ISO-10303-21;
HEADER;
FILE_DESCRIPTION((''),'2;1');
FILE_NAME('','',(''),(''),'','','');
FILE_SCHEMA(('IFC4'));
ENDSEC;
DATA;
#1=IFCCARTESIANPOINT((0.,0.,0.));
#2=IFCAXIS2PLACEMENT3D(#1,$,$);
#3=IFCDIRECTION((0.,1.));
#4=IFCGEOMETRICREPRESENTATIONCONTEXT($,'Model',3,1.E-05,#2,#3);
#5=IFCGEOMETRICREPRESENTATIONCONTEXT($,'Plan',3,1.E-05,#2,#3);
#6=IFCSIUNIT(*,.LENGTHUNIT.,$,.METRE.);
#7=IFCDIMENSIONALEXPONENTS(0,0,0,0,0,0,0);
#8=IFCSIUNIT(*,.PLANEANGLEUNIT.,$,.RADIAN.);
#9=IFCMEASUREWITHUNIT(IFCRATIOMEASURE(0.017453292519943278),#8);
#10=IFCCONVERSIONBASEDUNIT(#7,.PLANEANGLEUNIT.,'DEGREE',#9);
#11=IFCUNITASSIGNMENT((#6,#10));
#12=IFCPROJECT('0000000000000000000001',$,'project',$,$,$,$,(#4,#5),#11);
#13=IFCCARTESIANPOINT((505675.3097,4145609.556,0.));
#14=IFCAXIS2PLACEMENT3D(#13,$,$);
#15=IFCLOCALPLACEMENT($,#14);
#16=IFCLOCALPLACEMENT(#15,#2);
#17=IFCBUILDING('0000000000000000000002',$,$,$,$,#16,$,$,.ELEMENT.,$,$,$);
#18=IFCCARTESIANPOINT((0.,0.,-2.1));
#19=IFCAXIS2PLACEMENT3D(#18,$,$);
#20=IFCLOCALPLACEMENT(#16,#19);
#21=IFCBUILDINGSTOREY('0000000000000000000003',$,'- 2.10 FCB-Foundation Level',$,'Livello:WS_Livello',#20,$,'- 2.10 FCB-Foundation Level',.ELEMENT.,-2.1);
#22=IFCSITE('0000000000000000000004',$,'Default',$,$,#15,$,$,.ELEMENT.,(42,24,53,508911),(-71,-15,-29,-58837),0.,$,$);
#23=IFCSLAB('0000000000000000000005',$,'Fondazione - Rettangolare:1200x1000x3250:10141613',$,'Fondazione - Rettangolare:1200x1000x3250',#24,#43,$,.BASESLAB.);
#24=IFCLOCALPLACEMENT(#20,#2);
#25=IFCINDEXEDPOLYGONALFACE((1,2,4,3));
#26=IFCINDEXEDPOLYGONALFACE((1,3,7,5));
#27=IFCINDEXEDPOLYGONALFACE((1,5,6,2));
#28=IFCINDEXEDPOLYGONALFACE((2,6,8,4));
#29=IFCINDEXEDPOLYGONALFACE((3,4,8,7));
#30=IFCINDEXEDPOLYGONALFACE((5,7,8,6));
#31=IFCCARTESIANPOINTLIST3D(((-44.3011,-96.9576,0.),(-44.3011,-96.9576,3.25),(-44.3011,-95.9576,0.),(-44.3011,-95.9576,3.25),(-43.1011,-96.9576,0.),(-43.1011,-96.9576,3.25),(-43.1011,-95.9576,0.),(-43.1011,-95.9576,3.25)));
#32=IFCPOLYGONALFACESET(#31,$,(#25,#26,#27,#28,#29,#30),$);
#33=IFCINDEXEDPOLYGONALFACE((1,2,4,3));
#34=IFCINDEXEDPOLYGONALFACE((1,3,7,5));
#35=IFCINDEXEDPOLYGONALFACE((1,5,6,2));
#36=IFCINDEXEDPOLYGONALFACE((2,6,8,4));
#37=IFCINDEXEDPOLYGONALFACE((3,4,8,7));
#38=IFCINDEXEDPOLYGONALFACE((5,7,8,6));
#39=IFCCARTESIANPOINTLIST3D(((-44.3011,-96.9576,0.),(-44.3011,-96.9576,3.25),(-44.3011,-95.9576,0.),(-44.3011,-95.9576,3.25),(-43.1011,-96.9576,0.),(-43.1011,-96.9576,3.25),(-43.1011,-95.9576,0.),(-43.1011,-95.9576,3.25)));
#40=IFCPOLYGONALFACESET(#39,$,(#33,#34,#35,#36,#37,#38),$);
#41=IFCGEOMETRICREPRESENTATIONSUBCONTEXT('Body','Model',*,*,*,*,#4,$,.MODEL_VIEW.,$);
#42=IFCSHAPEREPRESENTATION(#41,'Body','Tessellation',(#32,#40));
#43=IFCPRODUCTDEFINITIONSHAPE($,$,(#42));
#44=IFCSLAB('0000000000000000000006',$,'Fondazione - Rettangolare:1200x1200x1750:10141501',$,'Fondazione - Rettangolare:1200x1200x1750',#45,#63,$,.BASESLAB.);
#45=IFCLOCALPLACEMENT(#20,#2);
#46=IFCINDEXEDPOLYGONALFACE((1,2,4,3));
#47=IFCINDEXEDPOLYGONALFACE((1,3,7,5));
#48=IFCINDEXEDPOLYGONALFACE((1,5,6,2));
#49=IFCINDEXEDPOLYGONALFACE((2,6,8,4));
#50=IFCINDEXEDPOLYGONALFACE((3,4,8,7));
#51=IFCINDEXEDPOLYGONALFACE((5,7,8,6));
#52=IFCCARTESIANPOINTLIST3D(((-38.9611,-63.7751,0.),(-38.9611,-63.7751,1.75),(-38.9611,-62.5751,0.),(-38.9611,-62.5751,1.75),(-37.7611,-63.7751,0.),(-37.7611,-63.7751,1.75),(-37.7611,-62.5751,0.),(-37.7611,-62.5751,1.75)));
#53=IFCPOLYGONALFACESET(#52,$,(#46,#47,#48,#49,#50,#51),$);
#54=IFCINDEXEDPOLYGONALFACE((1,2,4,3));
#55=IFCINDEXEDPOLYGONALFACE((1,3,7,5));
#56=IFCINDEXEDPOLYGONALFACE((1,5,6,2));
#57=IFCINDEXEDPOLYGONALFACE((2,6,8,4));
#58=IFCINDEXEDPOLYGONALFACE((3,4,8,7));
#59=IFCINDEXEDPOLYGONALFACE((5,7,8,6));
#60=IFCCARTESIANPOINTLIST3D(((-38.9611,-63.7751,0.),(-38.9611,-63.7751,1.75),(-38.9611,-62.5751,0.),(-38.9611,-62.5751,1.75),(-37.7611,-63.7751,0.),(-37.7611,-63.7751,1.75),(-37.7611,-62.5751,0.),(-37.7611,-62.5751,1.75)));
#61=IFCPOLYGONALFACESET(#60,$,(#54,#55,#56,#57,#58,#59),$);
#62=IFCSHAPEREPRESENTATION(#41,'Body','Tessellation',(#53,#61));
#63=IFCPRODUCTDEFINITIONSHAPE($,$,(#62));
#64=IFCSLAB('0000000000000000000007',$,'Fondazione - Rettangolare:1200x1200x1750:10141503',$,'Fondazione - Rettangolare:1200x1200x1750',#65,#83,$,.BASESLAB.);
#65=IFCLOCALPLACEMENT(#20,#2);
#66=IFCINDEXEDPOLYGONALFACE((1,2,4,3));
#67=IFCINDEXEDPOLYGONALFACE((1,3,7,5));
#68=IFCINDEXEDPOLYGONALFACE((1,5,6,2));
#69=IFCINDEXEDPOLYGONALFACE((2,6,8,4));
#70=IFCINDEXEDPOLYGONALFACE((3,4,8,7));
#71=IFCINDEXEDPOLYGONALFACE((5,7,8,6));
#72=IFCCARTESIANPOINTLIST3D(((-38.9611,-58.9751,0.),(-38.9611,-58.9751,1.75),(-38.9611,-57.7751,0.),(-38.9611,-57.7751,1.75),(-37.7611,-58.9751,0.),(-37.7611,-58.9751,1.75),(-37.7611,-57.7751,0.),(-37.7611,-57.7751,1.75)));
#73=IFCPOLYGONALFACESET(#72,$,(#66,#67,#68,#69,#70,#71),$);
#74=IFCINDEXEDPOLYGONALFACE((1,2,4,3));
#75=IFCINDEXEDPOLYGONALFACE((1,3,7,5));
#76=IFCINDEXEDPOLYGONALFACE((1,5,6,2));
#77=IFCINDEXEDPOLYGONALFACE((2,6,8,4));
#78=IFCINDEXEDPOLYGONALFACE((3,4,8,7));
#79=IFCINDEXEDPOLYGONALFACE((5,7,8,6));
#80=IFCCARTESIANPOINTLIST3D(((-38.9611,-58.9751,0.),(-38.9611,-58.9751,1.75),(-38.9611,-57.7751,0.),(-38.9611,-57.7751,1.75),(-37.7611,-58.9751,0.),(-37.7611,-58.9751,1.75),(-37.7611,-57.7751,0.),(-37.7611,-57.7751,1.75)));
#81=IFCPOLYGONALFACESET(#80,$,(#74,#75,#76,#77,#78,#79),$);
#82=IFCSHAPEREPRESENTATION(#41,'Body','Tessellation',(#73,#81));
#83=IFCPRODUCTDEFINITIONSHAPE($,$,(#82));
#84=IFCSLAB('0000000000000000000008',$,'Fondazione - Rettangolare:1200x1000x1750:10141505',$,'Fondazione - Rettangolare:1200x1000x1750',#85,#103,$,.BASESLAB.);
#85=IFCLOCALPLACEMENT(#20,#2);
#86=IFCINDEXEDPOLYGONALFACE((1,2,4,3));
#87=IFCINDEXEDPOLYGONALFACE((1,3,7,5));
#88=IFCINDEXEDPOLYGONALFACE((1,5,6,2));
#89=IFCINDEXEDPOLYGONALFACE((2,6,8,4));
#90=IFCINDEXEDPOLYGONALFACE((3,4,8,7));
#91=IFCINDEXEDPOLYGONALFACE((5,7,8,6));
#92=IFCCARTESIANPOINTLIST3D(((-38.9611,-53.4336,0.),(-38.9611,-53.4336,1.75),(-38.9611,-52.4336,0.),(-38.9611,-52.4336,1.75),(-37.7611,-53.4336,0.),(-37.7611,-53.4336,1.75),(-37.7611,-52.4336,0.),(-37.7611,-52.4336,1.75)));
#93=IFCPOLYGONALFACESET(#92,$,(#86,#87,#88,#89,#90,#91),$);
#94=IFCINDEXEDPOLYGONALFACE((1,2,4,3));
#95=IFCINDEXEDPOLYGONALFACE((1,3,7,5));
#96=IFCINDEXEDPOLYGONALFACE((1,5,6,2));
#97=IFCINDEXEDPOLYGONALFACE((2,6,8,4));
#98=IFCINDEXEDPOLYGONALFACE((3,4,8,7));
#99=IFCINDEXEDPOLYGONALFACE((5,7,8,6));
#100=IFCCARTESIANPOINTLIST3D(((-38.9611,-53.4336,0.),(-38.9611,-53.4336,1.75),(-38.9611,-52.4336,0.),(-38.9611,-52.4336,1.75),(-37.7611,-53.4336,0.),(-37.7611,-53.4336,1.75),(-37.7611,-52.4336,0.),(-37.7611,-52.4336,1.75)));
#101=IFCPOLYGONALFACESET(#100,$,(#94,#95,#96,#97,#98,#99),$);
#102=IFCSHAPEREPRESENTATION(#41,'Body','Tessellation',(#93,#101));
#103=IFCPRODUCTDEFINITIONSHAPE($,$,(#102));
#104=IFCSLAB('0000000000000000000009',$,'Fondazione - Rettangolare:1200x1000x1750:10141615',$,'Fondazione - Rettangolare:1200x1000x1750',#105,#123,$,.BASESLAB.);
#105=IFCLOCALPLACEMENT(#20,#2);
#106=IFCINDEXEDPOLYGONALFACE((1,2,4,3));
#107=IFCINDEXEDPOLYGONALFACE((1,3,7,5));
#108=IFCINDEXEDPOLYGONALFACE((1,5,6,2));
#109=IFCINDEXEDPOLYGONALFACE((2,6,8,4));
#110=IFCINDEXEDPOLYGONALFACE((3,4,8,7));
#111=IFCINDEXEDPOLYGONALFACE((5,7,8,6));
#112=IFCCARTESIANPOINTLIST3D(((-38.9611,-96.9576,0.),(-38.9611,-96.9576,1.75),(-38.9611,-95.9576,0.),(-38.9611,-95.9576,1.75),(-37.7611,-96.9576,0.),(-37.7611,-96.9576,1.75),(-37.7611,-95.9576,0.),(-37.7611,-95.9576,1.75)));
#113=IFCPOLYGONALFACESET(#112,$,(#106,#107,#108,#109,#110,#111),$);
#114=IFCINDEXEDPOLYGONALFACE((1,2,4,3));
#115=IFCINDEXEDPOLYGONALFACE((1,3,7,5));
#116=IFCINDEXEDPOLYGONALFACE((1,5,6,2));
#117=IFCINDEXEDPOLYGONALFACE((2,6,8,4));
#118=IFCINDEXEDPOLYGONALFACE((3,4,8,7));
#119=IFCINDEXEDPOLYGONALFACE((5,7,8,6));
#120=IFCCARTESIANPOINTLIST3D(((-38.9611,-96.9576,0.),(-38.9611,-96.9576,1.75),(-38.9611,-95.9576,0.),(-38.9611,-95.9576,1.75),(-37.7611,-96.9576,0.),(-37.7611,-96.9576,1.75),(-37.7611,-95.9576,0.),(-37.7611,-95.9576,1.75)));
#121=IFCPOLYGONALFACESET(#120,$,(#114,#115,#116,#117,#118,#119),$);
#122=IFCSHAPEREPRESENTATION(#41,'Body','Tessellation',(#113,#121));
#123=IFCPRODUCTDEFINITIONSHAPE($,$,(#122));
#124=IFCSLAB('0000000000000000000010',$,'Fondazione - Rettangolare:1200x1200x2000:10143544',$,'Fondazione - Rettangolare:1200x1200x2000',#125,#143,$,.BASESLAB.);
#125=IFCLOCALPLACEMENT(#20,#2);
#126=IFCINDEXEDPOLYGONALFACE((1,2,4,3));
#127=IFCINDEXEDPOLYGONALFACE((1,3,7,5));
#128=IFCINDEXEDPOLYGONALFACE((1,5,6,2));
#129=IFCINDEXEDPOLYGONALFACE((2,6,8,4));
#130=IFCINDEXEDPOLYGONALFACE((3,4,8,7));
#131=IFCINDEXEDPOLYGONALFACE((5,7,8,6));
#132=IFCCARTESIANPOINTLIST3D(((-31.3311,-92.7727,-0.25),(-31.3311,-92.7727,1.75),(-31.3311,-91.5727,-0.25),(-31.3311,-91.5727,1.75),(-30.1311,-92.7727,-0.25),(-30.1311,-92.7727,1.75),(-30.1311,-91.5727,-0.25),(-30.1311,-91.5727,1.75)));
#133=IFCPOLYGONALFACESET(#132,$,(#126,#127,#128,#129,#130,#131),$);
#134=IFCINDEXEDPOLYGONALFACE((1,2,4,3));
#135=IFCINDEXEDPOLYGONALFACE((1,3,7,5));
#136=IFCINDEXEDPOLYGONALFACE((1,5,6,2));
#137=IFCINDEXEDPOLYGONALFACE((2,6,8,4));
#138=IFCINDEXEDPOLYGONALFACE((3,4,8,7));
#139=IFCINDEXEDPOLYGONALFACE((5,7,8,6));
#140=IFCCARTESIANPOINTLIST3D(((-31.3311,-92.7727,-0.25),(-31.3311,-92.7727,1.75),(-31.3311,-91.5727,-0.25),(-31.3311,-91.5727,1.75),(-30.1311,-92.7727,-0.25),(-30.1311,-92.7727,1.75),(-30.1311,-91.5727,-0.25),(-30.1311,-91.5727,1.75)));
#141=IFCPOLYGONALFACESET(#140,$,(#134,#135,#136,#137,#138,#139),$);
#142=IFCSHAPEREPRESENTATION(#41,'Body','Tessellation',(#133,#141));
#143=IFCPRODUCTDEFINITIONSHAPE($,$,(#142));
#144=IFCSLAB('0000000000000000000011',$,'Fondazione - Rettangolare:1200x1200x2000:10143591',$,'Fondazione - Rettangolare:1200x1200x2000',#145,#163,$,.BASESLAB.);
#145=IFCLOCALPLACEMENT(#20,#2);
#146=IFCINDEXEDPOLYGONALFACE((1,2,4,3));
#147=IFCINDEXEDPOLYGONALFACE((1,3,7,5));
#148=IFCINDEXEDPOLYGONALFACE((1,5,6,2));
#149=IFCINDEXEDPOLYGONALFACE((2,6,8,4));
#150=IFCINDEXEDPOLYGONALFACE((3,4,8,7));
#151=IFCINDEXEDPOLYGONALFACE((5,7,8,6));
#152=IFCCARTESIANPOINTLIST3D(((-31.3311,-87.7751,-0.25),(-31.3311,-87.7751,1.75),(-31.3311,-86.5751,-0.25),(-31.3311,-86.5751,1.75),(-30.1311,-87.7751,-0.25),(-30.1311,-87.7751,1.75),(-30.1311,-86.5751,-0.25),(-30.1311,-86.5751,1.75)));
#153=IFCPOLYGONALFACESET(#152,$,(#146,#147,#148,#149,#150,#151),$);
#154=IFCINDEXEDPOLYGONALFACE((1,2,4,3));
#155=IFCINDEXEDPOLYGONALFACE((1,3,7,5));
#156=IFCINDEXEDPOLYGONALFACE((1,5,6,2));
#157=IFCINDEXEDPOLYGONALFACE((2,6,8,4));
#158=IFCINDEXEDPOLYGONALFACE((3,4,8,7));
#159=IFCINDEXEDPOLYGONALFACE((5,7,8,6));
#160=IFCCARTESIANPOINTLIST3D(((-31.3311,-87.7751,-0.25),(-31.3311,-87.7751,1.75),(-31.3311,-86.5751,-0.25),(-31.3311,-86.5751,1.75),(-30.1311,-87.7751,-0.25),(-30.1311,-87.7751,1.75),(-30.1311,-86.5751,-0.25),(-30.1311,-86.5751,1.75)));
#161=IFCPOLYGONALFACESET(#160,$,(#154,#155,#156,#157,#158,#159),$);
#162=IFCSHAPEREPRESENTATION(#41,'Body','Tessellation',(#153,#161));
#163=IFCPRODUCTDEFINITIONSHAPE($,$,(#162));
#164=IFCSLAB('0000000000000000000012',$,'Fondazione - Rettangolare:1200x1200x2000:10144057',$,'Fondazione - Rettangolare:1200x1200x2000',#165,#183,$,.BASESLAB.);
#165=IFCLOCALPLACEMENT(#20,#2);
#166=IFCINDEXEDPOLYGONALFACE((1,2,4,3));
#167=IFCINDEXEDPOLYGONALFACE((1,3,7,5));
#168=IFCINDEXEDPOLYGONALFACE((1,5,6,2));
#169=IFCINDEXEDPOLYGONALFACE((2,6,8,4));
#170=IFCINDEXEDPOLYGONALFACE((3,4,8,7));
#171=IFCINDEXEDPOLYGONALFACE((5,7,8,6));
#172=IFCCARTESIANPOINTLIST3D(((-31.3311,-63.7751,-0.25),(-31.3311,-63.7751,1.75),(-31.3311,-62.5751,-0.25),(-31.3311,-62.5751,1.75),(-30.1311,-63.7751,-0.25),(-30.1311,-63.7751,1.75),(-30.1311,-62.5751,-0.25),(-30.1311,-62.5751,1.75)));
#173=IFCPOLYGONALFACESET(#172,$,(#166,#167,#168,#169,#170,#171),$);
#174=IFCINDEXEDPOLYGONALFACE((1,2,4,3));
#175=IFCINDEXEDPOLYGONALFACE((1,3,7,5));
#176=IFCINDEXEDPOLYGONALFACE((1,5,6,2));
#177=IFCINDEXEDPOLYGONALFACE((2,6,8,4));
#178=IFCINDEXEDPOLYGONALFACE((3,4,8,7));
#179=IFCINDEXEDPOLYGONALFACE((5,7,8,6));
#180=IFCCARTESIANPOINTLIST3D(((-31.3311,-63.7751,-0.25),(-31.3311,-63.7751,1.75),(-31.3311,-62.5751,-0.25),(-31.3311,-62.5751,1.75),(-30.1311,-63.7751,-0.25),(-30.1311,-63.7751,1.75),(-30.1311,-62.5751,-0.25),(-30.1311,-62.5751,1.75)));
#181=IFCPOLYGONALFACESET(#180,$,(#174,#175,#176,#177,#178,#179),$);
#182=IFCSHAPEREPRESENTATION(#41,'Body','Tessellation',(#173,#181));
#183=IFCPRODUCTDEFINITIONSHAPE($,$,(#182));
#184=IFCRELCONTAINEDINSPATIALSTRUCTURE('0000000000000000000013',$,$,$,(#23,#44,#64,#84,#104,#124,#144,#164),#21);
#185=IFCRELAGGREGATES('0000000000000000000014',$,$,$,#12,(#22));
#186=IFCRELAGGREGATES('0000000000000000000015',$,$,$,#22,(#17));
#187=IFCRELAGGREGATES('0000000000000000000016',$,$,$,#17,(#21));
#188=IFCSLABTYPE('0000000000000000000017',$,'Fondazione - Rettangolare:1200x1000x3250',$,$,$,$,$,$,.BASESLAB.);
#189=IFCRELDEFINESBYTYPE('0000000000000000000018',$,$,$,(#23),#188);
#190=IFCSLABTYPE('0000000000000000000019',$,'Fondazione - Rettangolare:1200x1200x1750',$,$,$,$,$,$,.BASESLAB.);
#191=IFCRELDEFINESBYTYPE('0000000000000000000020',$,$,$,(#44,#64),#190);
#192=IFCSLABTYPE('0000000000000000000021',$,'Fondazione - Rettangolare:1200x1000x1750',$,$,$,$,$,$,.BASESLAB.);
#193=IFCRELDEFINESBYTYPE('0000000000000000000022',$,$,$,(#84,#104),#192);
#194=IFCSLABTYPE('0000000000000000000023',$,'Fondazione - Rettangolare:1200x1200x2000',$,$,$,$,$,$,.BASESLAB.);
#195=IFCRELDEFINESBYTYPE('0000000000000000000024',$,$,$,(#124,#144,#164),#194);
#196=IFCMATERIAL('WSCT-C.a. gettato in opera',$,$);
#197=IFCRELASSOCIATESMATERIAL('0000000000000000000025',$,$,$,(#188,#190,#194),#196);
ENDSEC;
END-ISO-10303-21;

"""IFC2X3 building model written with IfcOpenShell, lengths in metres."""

from ifc_helpers import new_model, entity, si_unit, converted_unit, direction, frame, frame_2d, origin, place, context, subcontext, project, spatial, rectangle, extrude, material, type_object, element, save


model = new_model("IFC2X3")

# Units and contexts
model_context = context("Model", 3, precision=1e-05, world=origin(), true_north=direction((0.0, 1.0)))
plan_context = context("Plan", 3, precision=1e-05, world=origin(), true_north=direction((0.0, 1.0)))
body_context = subcontext(model_context, "Body", "Model", "MODEL_VIEW")
ifc_project = project(units=[si_unit("LENGTHUNIT", "METRE"), converted_unit("PLANEANGLEUNIT", "DEGREE", entity("IfcRatioMeasure", 0.017453292519943278), si_unit("PLANEANGLEUNIT", "RADIAN"), dimensions=[0, 0, 0, 0, 0, 0, 0])], contexts=[model_context, plan_context])

# Site, building, storey
site_placement = place(None, frame((505675.3097, 4145609.556, 0.0)))
site = spatial("IfcSite", under=ifc_project, at=site_placement, Name="Default", CompositionType="ELEMENT", RefLatitude=(42, 24, 53, 508911), RefLongitude=(-71, -15, -29, -58837), RefElevation=0.0)
building_placement = place(site_placement, origin())
building = spatial("IfcBuilding", under=site, at=building_placement, CompositionType="ELEMENT")
storey_placement = place(building_placement, frame((0.0, 0.0, -2.1)))
storey = spatial("IfcBuildingStorey", under=building, at=storey_placement, Name="- 2.10 FCB-Foundation Level", ObjectType="Livello:WS_Livello", LongName="- 2.10 FCB-Foundation Level", CompositionType="ELEMENT", Elevation=-2.1)

# Slabs
ifc_material_1 = material(Name="WSCT-C.a. gettato in opera")
slab_type_1 = type_object("IfcSlabType", Name="Fondazione - Rettangolare:1200x1000x3250", PredefinedType="BASESLAB", material=ifc_material_1)
slab_1_placement = place(storey_placement, origin())
element("IfcSlab", 1, at=slab_1_placement, inside=storey, type_object=slab_type_1, Name="Fondazione - Rettangolare:1200x1000x3250:10141613", ObjectType="Fondazione - Rettangolare:1200x1000x3250", PredefinedType="BASESLAB", context=body_context, shape_type="SweptSolid", body=[
    extrude(rectangle(XDim=1.2, YDim=1.0, at=frame_2d((0.0, 0.0), x_axis=(1.0, 0.0))), frame((-43.7011, -96.4576, 0.0), z_axis=(0.0, 0.0, 1.0), x_axis=(-1.0, 0.0, 0.0)), (0.0, 0.0, 1.0), 3.25),
    extrude(rectangle(XDim=1.2, YDim=1.0, at=frame_2d((0.0, 0.0), x_axis=(1.0, 0.0))), frame((-43.7011, -96.4576, 0.0), z_axis=(0.0, 0.0, 1.0), x_axis=(-1.0, 0.0, 0.0)), (0.0, 0.0, 1.0), 3.25),
])
slab_type_2 = type_object("IfcSlabType", Name="Fondazione - Rettangolare:1200x1200x1750", PredefinedType="BASESLAB", material=ifc_material_1)
slab_2_placement = place(storey_placement, origin())
element("IfcSlab", 2, at=slab_2_placement, inside=storey, type_object=slab_type_2, Name="Fondazione - Rettangolare:1200x1200x1750:10141501", ObjectType="Fondazione - Rettangolare:1200x1200x1750", PredefinedType="BASESLAB", context=body_context, shape_type="SweptSolid", body=[
    extrude(rectangle(XDim=1.2, YDim=1.2, at=frame_2d((0.0, 0.0), x_axis=(1.0, 0.0))), frame((-38.3611, -63.1751, 0.0), z_axis=(0.0, 0.0, 1.0), x_axis=(-1.0, 0.0, 0.0)), (0.0, 0.0, 1.0), 1.75),
    extrude(rectangle(XDim=1.2, YDim=1.2, at=frame_2d((0.0, 0.0), x_axis=(1.0, 0.0))), frame((-38.3611, -63.1751, 0.0), z_axis=(0.0, 0.0, 1.0), x_axis=(-1.0, 0.0, 0.0)), (0.0, 0.0, 1.0), 1.75),
])
slab_3_placement = place(storey_placement, origin())
element("IfcSlab", 3, at=slab_3_placement, inside=storey, type_object=slab_type_2, Name="Fondazione - Rettangolare:1200x1200x1750:10141503", ObjectType="Fondazione - Rettangolare:1200x1200x1750", PredefinedType="BASESLAB", context=body_context, shape_type="SweptSolid", body=[
    extrude(rectangle(XDim=1.2, YDim=1.2, at=frame_2d((0.0, 0.0), x_axis=(1.0, 0.0))), frame((-38.3611, -58.3751, 0.0), z_axis=(0.0, 0.0, 1.0), x_axis=(-1.0, 0.0, 0.0)), (0.0, 0.0, 1.0), 1.75),
    extrude(rectangle(XDim=1.2, YDim=1.2, at=frame_2d((0.0, 0.0), x_axis=(1.0, 0.0))), frame((-38.3611, -58.3751, 0.0), z_axis=(0.0, 0.0, 1.0), x_axis=(-1.0, 0.0, 0.0)), (0.0, 0.0, 1.0), 1.75),
])
slab_type_3 = type_object("IfcSlabType", Name="Fondazione - Rettangolare:1200x1000x1750", PredefinedType="BASESLAB")
slab_4_placement = place(storey_placement, origin())
element("IfcSlab", 4, at=slab_4_placement, inside=storey, type_object=slab_type_3, Name="Fondazione - Rettangolare:1200x1000x1750:10141505", ObjectType="Fondazione - Rettangolare:1200x1000x1750", PredefinedType="BASESLAB", context=body_context, shape_type="SweptSolid", body=[
    extrude(rectangle(XDim=1.2, YDim=1.0, at=frame_2d((0.0, 0.0), x_axis=(1.0, 0.0))), frame((-38.3611, -52.9336, 0.0), z_axis=(0.0, 0.0, 1.0), x_axis=(-1.0, 0.0, 0.0)), (0.0, 0.0, 1.0), 1.75),
    extrude(rectangle(XDim=1.2, YDim=1.0, at=frame_2d((0.0, 0.0), x_axis=(1.0, 0.0))), frame((-38.3611, -52.9336, 0.0), z_axis=(0.0, 0.0, 1.0), x_axis=(-1.0, 0.0, 0.0)), (0.0, 0.0, 1.0), 1.75),
])
slab_5_placement = place(storey_placement, origin())
element("IfcSlab", 5, at=slab_5_placement, inside=storey, type_object=slab_type_3, Name="Fondazione - Rettangolare:1200x1000x1750:10141615", ObjectType="Fondazione - Rettangolare:1200x1000x1750", PredefinedType="BASESLAB", context=body_context, shape_type="SweptSolid", body=[
    extrude(rectangle(XDim=1.2, YDim=1.0, at=frame_2d((0.0, 0.0), x_axis=(1.0, 0.0))), frame((-38.3611, -96.4576, 0.0), z_axis=(0.0, 0.0, 1.0), x_axis=(-1.0, 0.0, 0.0)), (0.0, 0.0, 1.0), 1.75),
    extrude(rectangle(XDim=1.2, YDim=1.0, at=frame_2d((0.0, 0.0), x_axis=(1.0, 0.0))), frame((-38.3611, -96.4576, 0.0), z_axis=(0.0, 0.0, 1.0), x_axis=(-1.0, 0.0, 0.0)), (0.0, 0.0, 1.0), 1.75),
])
slab_type_4 = type_object("IfcSlabType", Name="Fondazione - Rettangolare:1200x1200x2000", PredefinedType="BASESLAB", material=ifc_material_1)
slab_6_placement = place(storey_placement, origin())
element("IfcSlab", 6, at=slab_6_placement, inside=storey, type_object=slab_type_4, Name="Fondazione - Rettangolare:1200x1200x2000:10143544", ObjectType="Fondazione - Rettangolare:1200x1200x2000", PredefinedType="BASESLAB", context=body_context, shape_type="SweptSolid", body=[
    extrude(rectangle(XDim=1.2, YDim=1.2, at=frame_2d((0.0, 0.0), x_axis=(1.0, 0.0))), frame((-30.7311, -92.1727, -0.25), z_axis=(0.0, 0.0, 1.0), x_axis=(-1.0, 0.0, 0.0)), (0.0, 0.0, 1.0), 2.0),
    extrude(rectangle(XDim=1.2, YDim=1.2, at=frame_2d((0.0, 0.0), x_axis=(1.0, 0.0))), frame((-30.7311, -92.1727, -0.25), z_axis=(0.0, 0.0, 1.0), x_axis=(-1.0, 0.0, 0.0)), (0.0, 0.0, 1.0), 2.0),
])
slab_7_placement = place(storey_placement, origin())
element("IfcSlab", 7, at=slab_7_placement, inside=storey, type_object=slab_type_4, Name="Fondazione - Rettangolare:1200x1200x2000:10143591", ObjectType="Fondazione - Rettangolare:1200x1200x2000", PredefinedType="BASESLAB", context=body_context, shape_type="SweptSolid", body=[
    extrude(rectangle(XDim=1.2, YDim=1.2, at=frame_2d((0.0, 0.0), x_axis=(1.0, 0.0))), frame((-30.7311, -87.1751, -0.25), z_axis=(0.0, 0.0, 1.0), x_axis=(-1.0, 0.0, 0.0)), (0.0, 0.0, 1.0), 2.0),
    extrude(rectangle(XDim=1.2, YDim=1.2, at=frame_2d((0.0, 0.0), x_axis=(1.0, 0.0))), frame((-30.7311, -87.1751, -0.25), z_axis=(0.0, 0.0, 1.0), x_axis=(-1.0, 0.0, 0.0)), (0.0, 0.0, 1.0), 2.0),
])
slab_8_placement = place(storey_placement, origin())
element("IfcSlab", 8, at=slab_8_placement, inside=storey, type_object=slab_type_4, Name="Fondazione - Rettangolare:1200x1200x2000:10144057", ObjectType="Fondazione - Rettangolare:1200x1200x2000", PredefinedType="BASESLAB", context=body_context, shape_type="SweptSolid", body=[
    extrude(rectangle(XDim=1.2, YDim=1.2, at=frame_2d((0.0, 0.0), x_axis=(1.0, 0.0))), frame((-30.7311, -63.1751, -0.25), z_axis=(0.0, 0.0, 1.0), x_axis=(-1.0, 0.0, 0.0)), (0.0, 0.0, 1.0), 2.0),
    extrude(rectangle(XDim=1.2, YDim=1.2, at=frame_2d((0.0, 0.0), x_axis=(1.0, 0.0))), frame((-30.7311, -63.1751, -0.25), z_axis=(0.0, 0.0, 1.0), x_axis=(-1.0, 0.0, 0.0)), (0.0, 0.0, 1.0), 2.0),
])

save(model, "model.ifc")
